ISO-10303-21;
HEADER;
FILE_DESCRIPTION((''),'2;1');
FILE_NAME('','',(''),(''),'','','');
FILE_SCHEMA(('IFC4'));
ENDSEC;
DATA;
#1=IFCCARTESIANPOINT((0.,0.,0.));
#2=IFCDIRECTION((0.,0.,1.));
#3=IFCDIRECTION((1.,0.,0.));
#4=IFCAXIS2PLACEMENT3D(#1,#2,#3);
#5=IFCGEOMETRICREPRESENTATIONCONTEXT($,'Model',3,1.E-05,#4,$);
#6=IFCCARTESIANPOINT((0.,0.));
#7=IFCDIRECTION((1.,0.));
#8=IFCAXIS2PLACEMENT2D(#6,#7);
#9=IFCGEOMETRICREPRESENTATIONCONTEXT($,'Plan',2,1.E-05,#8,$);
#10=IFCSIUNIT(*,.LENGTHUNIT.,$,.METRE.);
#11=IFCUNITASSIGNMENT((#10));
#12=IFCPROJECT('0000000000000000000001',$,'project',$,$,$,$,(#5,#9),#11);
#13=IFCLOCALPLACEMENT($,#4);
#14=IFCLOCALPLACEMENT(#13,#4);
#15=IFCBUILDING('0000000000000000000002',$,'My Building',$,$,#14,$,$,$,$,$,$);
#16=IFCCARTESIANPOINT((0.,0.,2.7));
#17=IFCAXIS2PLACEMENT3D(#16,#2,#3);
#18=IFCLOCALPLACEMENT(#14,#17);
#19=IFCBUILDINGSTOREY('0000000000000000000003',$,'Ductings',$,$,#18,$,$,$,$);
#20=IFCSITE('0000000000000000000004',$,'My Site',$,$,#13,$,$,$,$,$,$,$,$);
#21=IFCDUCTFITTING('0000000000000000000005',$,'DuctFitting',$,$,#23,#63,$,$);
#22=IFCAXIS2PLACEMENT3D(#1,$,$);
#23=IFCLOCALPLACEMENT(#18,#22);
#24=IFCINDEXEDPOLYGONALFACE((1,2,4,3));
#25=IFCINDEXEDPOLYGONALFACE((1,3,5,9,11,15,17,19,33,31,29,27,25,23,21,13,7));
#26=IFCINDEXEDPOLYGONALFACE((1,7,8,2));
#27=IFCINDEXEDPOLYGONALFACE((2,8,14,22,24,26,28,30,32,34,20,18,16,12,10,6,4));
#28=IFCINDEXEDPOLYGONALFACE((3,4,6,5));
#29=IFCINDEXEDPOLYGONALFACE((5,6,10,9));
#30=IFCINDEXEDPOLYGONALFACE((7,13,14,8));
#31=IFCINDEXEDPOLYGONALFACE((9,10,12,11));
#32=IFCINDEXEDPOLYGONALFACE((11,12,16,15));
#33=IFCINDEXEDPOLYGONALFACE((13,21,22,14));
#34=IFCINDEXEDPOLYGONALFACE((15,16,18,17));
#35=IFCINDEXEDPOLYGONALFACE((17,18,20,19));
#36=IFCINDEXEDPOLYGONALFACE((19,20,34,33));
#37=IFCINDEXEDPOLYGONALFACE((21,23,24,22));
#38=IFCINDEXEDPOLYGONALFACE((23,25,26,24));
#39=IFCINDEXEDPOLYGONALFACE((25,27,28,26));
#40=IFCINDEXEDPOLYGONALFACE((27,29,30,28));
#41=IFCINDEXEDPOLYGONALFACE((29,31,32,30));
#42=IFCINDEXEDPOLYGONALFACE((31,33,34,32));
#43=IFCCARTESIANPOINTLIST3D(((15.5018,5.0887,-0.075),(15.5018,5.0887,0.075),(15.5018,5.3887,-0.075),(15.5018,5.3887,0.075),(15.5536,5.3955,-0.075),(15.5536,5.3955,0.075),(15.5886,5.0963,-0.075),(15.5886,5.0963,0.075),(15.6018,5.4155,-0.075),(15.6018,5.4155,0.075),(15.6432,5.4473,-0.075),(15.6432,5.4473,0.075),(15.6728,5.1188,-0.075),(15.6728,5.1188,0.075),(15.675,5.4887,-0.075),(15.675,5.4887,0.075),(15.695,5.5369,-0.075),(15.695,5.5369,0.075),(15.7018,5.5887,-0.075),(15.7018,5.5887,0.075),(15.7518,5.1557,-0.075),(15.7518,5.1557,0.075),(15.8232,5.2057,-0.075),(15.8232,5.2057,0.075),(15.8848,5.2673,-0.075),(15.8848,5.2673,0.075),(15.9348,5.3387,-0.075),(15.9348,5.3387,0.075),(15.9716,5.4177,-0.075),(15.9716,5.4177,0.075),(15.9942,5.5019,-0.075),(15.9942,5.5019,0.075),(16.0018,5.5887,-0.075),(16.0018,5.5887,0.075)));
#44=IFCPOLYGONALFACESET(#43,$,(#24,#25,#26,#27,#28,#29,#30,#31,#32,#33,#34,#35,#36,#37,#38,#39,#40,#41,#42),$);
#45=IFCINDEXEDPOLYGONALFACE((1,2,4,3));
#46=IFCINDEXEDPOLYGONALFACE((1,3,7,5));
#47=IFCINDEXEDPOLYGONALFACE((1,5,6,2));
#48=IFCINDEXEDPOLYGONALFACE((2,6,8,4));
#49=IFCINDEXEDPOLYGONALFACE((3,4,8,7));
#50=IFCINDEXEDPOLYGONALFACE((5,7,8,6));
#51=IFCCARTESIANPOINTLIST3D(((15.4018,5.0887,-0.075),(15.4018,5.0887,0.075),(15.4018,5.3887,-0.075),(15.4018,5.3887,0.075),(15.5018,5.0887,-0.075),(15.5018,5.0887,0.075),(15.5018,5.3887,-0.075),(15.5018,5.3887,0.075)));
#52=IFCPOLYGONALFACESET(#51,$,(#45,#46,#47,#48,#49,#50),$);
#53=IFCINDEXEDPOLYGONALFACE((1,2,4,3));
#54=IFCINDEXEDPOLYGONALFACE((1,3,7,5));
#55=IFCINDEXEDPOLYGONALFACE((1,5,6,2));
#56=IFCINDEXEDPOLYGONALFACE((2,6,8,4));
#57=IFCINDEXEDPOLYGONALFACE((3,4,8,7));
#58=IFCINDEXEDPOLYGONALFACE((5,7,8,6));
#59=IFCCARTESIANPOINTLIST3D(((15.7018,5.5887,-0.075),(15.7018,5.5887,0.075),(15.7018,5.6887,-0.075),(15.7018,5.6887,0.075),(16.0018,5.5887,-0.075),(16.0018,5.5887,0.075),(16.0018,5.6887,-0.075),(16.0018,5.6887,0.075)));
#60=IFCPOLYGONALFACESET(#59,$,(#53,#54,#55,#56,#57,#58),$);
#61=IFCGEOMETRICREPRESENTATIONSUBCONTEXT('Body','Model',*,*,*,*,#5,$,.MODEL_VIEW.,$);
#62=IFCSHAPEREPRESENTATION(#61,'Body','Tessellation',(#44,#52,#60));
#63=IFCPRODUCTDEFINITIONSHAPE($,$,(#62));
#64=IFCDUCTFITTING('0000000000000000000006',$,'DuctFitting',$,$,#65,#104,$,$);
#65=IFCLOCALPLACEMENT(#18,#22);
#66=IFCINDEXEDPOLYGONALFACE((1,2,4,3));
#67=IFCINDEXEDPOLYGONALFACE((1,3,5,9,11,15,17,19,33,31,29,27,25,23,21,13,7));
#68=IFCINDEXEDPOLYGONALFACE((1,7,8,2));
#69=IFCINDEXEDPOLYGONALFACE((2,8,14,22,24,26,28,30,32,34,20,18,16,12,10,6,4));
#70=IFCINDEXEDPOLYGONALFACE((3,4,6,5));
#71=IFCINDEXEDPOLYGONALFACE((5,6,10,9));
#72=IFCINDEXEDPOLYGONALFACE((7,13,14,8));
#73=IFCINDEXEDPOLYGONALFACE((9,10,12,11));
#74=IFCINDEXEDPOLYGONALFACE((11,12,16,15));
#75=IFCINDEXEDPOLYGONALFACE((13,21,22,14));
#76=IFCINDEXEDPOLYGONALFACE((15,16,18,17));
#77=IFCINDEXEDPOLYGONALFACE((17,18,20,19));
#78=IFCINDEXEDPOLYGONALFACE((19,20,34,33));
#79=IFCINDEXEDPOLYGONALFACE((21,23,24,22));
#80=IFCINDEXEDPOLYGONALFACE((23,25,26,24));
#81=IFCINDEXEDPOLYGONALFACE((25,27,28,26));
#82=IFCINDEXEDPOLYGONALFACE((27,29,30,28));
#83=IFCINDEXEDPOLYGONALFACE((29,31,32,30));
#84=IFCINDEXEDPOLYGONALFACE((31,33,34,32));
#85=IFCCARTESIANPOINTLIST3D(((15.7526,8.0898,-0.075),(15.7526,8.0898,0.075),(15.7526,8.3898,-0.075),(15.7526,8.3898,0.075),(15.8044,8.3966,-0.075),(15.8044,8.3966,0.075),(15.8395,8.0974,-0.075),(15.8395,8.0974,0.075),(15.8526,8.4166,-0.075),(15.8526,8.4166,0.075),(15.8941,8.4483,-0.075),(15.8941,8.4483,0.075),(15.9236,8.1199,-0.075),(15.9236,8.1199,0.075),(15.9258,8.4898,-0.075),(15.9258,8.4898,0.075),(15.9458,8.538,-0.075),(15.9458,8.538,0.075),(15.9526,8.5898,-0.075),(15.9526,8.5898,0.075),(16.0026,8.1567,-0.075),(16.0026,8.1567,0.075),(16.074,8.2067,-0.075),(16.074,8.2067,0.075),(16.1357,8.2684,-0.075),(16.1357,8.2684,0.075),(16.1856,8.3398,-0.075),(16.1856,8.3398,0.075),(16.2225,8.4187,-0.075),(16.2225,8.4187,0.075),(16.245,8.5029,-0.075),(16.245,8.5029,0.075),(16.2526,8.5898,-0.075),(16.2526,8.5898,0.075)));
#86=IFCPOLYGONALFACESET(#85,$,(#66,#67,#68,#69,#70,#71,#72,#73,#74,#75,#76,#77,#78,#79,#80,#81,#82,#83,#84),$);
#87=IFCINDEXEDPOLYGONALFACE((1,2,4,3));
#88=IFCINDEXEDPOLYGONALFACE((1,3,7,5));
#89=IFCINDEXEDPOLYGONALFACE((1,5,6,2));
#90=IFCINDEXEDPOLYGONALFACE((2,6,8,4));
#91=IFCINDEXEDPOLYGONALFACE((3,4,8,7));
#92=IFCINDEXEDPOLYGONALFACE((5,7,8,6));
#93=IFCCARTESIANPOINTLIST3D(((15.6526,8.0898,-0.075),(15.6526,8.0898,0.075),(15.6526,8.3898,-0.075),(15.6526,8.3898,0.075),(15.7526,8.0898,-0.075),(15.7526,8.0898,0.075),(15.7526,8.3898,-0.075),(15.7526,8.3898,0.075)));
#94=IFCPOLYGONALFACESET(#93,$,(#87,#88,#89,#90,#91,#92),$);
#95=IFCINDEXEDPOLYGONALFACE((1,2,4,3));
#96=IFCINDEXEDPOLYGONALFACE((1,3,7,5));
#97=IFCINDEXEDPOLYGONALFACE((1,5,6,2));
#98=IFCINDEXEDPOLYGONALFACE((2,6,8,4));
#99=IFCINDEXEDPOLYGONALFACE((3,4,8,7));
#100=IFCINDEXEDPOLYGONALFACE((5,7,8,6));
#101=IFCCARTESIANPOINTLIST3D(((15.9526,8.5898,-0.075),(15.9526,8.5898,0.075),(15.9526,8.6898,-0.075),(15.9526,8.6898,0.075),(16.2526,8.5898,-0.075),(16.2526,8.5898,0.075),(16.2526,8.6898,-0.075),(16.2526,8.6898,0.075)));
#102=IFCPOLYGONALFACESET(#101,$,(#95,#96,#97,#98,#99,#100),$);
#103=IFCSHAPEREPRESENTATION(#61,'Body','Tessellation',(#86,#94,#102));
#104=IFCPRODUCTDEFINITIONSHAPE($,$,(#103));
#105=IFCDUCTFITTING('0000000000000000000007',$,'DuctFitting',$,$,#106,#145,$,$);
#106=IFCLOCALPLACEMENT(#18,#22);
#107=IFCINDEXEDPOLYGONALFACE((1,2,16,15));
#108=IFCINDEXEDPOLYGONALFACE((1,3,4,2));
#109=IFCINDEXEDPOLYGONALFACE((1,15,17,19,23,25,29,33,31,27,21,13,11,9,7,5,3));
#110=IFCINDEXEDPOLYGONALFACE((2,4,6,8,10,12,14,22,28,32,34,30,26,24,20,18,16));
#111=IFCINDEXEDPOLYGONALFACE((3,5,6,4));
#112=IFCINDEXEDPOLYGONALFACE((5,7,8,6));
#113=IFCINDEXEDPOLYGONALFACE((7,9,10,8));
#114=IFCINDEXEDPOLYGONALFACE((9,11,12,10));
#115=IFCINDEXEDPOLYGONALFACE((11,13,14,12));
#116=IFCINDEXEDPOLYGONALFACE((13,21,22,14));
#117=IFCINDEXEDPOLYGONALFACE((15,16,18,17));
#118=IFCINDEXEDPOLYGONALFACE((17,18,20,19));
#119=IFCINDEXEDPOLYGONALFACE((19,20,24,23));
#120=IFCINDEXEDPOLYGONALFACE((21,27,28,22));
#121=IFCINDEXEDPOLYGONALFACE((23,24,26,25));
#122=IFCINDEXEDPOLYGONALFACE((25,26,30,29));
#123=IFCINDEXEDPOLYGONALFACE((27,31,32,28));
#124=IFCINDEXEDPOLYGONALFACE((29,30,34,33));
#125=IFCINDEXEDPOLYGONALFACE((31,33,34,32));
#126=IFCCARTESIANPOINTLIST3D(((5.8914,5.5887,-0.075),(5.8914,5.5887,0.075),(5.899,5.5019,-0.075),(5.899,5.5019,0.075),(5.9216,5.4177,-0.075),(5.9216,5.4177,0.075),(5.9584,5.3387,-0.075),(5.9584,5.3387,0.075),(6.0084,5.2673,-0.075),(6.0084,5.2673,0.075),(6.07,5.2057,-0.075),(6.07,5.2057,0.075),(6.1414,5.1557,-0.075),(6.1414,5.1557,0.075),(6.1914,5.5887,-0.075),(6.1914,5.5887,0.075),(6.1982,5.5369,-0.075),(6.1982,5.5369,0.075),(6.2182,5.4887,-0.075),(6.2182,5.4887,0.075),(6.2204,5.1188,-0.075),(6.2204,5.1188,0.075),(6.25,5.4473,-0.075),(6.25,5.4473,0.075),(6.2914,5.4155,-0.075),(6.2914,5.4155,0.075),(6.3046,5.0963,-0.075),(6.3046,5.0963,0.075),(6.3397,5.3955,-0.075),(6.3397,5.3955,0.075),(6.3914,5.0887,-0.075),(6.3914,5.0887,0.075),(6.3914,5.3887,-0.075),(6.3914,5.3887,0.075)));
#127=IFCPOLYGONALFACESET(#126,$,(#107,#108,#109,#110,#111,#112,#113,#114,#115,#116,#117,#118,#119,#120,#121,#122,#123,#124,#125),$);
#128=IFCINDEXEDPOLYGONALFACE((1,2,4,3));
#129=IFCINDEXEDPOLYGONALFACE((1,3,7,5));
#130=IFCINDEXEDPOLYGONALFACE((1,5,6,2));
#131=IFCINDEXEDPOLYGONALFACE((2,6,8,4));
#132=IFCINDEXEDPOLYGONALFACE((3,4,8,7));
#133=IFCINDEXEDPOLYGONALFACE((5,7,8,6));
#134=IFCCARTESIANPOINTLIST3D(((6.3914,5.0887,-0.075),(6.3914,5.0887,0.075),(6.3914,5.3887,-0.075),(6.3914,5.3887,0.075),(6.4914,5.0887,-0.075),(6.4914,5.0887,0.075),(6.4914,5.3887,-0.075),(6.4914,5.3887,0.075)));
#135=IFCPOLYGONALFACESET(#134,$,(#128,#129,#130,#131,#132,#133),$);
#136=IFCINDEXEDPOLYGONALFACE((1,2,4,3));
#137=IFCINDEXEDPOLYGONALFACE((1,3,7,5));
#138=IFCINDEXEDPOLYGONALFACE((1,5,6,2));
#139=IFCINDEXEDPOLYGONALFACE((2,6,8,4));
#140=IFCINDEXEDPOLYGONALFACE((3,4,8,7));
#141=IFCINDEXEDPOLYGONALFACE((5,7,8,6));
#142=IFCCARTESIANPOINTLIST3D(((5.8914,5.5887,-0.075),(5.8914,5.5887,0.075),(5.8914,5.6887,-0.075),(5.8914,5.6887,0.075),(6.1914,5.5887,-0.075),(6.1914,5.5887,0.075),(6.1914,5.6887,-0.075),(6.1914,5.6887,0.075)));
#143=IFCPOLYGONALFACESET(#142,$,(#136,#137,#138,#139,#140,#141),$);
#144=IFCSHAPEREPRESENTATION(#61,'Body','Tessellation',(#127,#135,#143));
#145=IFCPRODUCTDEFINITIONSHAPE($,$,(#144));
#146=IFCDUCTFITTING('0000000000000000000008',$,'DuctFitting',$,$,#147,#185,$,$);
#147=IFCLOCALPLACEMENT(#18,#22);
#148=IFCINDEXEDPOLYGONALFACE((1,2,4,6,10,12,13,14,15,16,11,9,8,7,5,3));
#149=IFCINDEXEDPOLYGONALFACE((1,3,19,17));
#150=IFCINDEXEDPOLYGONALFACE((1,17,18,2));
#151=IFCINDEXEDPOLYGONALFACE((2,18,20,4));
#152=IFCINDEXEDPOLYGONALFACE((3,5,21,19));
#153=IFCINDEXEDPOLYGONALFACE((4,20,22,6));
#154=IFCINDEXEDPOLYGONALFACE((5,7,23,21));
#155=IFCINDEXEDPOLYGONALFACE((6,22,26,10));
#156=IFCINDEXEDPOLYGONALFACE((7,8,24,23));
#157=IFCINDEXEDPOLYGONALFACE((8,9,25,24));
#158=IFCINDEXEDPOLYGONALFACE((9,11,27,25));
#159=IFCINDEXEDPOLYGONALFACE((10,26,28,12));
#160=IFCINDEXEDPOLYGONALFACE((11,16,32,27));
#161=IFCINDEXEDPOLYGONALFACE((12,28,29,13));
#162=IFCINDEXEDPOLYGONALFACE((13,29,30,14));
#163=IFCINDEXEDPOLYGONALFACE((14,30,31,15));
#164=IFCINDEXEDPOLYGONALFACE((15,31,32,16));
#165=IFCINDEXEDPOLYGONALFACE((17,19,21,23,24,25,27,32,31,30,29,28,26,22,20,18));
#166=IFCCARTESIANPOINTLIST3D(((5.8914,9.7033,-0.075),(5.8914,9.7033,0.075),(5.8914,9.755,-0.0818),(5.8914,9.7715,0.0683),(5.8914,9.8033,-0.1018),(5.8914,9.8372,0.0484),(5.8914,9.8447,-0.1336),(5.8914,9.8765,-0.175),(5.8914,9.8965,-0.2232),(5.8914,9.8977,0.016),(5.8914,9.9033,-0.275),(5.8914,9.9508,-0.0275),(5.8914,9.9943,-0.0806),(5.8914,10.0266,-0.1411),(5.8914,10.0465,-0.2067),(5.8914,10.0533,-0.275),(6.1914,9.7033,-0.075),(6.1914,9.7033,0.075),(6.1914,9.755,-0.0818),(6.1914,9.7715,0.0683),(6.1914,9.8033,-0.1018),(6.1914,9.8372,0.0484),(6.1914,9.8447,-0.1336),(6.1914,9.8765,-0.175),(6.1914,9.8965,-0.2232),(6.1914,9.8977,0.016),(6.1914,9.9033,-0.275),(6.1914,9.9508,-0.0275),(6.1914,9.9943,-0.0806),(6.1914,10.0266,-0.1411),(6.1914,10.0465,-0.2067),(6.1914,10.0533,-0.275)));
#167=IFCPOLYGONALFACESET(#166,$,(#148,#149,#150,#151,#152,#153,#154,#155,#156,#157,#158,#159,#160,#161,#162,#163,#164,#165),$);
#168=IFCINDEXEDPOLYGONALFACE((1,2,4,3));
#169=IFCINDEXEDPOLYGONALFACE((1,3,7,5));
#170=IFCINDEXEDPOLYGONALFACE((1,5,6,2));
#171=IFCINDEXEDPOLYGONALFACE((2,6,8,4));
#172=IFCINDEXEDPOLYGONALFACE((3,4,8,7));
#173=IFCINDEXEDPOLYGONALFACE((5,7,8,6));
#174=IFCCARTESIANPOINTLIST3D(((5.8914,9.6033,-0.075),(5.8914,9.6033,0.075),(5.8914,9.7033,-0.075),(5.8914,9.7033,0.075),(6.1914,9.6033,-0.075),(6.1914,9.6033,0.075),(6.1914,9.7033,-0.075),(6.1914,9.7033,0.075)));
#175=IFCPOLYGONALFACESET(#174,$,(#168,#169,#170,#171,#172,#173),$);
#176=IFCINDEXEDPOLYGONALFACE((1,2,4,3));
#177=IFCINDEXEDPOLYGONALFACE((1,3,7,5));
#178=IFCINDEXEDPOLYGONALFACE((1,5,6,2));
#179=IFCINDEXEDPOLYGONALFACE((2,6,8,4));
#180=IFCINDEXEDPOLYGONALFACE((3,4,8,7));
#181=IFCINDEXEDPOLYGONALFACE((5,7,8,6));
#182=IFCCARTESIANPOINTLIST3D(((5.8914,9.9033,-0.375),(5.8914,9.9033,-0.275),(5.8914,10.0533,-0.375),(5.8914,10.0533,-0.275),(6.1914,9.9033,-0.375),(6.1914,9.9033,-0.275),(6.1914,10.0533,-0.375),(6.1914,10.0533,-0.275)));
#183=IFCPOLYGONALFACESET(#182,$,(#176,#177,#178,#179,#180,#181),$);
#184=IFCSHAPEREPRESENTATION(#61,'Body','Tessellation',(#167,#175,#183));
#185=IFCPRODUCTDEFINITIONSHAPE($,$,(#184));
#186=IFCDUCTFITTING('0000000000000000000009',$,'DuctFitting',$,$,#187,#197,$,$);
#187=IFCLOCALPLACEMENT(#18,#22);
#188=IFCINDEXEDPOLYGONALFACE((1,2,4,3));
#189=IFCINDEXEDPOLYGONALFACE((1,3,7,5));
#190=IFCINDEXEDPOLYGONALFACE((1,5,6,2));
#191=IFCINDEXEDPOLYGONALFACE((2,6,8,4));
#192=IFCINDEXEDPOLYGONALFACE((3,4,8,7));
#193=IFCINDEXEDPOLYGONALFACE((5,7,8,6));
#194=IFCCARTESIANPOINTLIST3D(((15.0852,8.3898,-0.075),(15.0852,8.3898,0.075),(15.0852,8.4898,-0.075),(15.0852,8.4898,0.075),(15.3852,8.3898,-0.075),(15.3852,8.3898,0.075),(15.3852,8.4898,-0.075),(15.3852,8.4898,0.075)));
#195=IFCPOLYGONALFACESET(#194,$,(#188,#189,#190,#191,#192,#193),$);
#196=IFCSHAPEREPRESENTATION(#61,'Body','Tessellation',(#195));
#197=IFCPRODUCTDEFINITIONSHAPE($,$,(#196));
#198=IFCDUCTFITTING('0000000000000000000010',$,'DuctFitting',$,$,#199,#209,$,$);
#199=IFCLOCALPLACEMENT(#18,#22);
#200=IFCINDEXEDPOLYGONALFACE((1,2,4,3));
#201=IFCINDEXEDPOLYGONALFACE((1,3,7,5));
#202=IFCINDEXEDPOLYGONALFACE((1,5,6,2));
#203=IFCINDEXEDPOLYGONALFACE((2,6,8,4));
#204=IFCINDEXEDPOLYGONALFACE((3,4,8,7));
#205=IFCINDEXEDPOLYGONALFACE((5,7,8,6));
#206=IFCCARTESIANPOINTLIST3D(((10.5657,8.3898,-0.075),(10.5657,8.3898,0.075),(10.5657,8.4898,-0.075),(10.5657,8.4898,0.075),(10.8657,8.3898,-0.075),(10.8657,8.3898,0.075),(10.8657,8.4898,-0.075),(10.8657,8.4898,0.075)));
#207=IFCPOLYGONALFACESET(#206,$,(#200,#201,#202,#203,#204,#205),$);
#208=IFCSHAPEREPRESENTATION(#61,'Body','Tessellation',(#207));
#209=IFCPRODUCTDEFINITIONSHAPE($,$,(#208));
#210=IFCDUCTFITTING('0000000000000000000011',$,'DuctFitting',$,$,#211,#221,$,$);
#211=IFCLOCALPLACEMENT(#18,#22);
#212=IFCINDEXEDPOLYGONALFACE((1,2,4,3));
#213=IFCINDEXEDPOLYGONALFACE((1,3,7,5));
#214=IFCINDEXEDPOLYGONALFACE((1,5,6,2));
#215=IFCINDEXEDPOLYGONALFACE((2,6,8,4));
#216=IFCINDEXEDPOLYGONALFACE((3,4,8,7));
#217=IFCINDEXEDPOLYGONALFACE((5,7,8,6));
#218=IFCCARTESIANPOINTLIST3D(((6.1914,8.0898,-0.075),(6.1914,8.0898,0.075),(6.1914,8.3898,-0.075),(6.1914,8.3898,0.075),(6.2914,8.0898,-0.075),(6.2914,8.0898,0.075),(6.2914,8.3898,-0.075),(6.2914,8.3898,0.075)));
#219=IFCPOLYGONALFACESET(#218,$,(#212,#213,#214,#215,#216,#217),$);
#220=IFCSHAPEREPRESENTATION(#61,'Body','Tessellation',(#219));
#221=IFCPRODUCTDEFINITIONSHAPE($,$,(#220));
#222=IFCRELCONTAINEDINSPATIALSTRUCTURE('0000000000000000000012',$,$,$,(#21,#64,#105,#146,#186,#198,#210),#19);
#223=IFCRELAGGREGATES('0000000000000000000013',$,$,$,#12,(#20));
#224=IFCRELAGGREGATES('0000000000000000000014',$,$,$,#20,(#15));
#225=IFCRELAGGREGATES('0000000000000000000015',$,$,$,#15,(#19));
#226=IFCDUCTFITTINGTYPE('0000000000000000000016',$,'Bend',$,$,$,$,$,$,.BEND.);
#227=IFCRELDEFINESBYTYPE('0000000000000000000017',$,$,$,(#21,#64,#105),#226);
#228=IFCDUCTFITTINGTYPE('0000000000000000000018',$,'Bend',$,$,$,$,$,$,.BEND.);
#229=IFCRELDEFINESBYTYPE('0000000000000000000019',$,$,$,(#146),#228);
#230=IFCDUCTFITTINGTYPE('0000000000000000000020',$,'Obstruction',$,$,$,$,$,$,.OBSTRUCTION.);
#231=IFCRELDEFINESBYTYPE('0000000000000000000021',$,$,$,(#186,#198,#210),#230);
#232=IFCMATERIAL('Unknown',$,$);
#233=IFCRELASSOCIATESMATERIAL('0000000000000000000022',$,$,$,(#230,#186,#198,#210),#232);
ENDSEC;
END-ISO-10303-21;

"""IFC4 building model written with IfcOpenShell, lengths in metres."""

from ifc_helpers import new_model, si_unit, frame, origin_with_axes, origin_2d_with_axis, place, context, subcontext, project, spatial, line, arc, indexed_curve, rectangle, outline, extrude, source, transform, mapped, material, material_profile, profile_set, profile_usage, type_object, type_shapes, element, save


model = new_model("IFC4")

# Units and contexts
model_context = context("Model", 3, precision=1e-05, world=origin_with_axes())
plan_context = context("Plan", 2, precision=1e-05, world=origin_2d_with_axis())
body_context = subcontext(model_context, "Body", "Model", "MODEL_VIEW")
ifc_project = project(units=[si_unit("LENGTHUNIT", "METRE")], contexts=[model_context, plan_context])

# Site, building, storey
site_placement = place(None, origin_with_axes())
site = spatial("IfcSite", under=ifc_project, at=site_placement, Name="My Site")
building_placement = place(site_placement, origin_with_axes())
building = spatial("IfcBuilding", under=site, at=building_placement, Name="My Building")
storey_placement = place(building_placement, frame((0.0, 0.0, 2.7), z_axis=(0.0, 0.0, 1.0), x_axis=(1.0, 0.0, 0.0)))
storey = spatial("IfcBuildingStorey", under=building, at=storey_placement, Name="Ductings")

# Shared definitions
ifc_material = material(Name="Unknown")

# Duct fittings
duct_fitting_type_1 = type_object("IfcDuctFittingType", Name="Bend", PredefinedType="BEND")
shared_shape_1 = source(origin_with_axes(), body_context, "Body", "SweptSolid", [
    extrude(outline(indexed_curve([(0.15, 0.0), (0.2086, -0.1414), (0.35, -0.2), (0.35, -0.5), (-0.0036, -0.3536), (-0.15, 0.0)], segments=[arc(1, 2, 3), line(3, 4), arc(4, 5, 6), line(6, 1)])), frame((0.0, -0.075, -0.1), z_axis=(0.0, -1.0, 0.0), x_axis=(1.0, 0.0, 0.0)), (0.0, 0.0, -1.0), 0.15),
    extrude(rectangle(XDim=0.3, YDim=0.15), origin_with_axes(), (0.0, 0.0, -1.0), 0.1),
    extrude(rectangle(XDim=0.3, YDim=0.15), frame((0.35, 0.0, -0.45), z_axis=(1.0, 0.0, 0.0), x_axis=(0.0, 0.0, 1.0)), (0.0, 0.0, 1.0), 0.1),
])
type_shapes(duct_fitting_type_1, [shared_shape_1])
for number, where, z_axis, x_axis, name in (
    (1, (15.4018, 5.2387, 0.0), (-1.0, 0.0, -0.000001), (0.0, 1.0, 0.0), "DuctFitting"),
    (2, (15.6526, 8.2398, 0.0), (-1.0, 0.0, 0.0), (0.0, 1.0, 0.0), "DuctFitting"),
    (3, (6.4914, 5.2387, 0.0), (1.0, 0.0, 0.0), (0.0, 1.0, 0.0), "DuctFitting"),
):
    element("IfcDuctFitting", number, at=place(storey_placement, frame(where, z_axis=z_axis, x_axis=x_axis)), inside=storey, type_object=duct_fitting_type_1, Name=name, context=body_context, shape_type="MappedRepresentation", body=[
        mapped(shared_shape_1, transform((0.0, 0.0, 0.0), x_axis=(1.0, 0.0, 0.0), y_axis=(0.0, 1.0, 0.0), z_axis=(0.0, 0.0, 1.0), scale=1.0)),
    ])
duct_fitting_type_2 = type_object("IfcDuctFittingType", Name="Bend", PredefinedType="BEND")
shared_shape_2 = source(origin_with_axes(), body_context, "Body", "SweptSolid", [
    extrude(outline(indexed_curve([(-0.075, 0.0), (-0.1336, -0.1414), (-0.275, -0.2), (-0.275, -0.35), (-0.0275, -0.2475), (0.075, 0.0)], segments=[arc(1, 2, 3), line(3, 4), arc(4, 5, 6), line(6, 1)])), frame((-0.15, 0.0, -0.1), z_axis=(1.0, 0.0, 0.0), x_axis=(0.0, 1.0, 0.0)), (0.0, 0.0, 1.0), 0.3),
    extrude(rectangle(XDim=0.3, YDim=0.15), origin_with_axes(), (0.0, 0.0, -1.0), 0.1),
    extrude(rectangle(XDim=0.3, YDim=0.15), frame((0.0, -0.275, -0.375), z_axis=(0.0, -1.0, 0.0), x_axis=(1.0, 0.0, 0.0)), (0.0, 0.0, 1.0), 0.1),
])
type_shapes(duct_fitting_type_2, [shared_shape_2])
duct_fitting_1_placement = place(storey_placement, frame((6.0414, 9.6033, 0.0), z_axis=(0.0, -1.0, 0.0), x_axis=(1.0, 0.0, 0.0)))
element("IfcDuctFitting", 4, at=duct_fitting_1_placement, inside=storey, type_object=duct_fitting_type_2, Name="DuctFitting", context=body_context, shape_type="MappedRepresentation", body=[
    mapped(shared_shape_2, transform((0.0, 0.0, 0.0), x_axis=(1.0, 0.0, 0.0), y_axis=(0.0, 1.0, 0.0), z_axis=(0.0, 0.0, 1.0), scale=1.0)),
])
ifc_material_profile_1 = material_profile(ifc_material, rectangle(XDim=0.3, YDim=0.15))
ifc_profile_set_1 = profile_set([ifc_material_profile_1])
ifc_profile_usage_1 = profile_usage(ifc_profile_set_1, cardinal=5)
duct_fitting_type_3 = type_object("IfcDuctFittingType", Name="Obstruction", PredefinedType="OBSTRUCTION", material=ifc_profile_set_1)
duct_fitting_2_placement = place(storey_placement, frame((15.2352, 8.3898, 0.0), z_axis=(0.0, 1.0, 0.0), x_axis=(-1.0, 0.0, 0.0)))
element("IfcDuctFitting", 5, at=duct_fitting_2_placement, inside=storey, type_object=duct_fitting_type_3, material=ifc_profile_usage_1, Name="DuctFitting", context=body_context, shape_type="SweptSolid", body=[
    extrude(rectangle(XDim=0.3, YDim=0.15), origin_with_axes(), (0.0, 0.0, 1.0), 0.1),
])
ifc_profile_usage_2 = profile_usage(ifc_profile_set_1, cardinal=5)
duct_fitting_3_placement = place(storey_placement, frame((10.7157, 8.3898, 0.0), z_axis=(0.0, 1.0, 0.0), x_axis=(-1.0, 0.0, 0.0)))
element("IfcDuctFitting", 6, at=duct_fitting_3_placement, inside=storey, type_object=duct_fitting_type_3, material=ifc_profile_usage_2, Name="DuctFitting", context=body_context, shape_type="SweptSolid", body=[
    extrude(rectangle(XDim=0.3, YDim=0.15), origin_with_axes(), (0.0, 0.0, 1.0), 0.1),
])
ifc_profile_usage_3 = profile_usage(ifc_profile_set_1, cardinal=5)
duct_fitting_4_placement = place(storey_placement, frame((6.1914, 8.2398, 0.0), z_axis=(1.0, 0.0, 0.0), x_axis=(0.0, 1.0, 0.0)))
element("IfcDuctFitting", 7, at=duct_fitting_4_placement, inside=storey, type_object=duct_fitting_type_3, material=ifc_profile_usage_3, Name="DuctFitting", context=body_context, shape_type="SweptSolid", body=[
    extrude(rectangle(XDim=0.3, YDim=0.15), origin_with_axes(), (0.0, 0.0, 1.0), 0.1),
])

save(model, "model.ifc")
